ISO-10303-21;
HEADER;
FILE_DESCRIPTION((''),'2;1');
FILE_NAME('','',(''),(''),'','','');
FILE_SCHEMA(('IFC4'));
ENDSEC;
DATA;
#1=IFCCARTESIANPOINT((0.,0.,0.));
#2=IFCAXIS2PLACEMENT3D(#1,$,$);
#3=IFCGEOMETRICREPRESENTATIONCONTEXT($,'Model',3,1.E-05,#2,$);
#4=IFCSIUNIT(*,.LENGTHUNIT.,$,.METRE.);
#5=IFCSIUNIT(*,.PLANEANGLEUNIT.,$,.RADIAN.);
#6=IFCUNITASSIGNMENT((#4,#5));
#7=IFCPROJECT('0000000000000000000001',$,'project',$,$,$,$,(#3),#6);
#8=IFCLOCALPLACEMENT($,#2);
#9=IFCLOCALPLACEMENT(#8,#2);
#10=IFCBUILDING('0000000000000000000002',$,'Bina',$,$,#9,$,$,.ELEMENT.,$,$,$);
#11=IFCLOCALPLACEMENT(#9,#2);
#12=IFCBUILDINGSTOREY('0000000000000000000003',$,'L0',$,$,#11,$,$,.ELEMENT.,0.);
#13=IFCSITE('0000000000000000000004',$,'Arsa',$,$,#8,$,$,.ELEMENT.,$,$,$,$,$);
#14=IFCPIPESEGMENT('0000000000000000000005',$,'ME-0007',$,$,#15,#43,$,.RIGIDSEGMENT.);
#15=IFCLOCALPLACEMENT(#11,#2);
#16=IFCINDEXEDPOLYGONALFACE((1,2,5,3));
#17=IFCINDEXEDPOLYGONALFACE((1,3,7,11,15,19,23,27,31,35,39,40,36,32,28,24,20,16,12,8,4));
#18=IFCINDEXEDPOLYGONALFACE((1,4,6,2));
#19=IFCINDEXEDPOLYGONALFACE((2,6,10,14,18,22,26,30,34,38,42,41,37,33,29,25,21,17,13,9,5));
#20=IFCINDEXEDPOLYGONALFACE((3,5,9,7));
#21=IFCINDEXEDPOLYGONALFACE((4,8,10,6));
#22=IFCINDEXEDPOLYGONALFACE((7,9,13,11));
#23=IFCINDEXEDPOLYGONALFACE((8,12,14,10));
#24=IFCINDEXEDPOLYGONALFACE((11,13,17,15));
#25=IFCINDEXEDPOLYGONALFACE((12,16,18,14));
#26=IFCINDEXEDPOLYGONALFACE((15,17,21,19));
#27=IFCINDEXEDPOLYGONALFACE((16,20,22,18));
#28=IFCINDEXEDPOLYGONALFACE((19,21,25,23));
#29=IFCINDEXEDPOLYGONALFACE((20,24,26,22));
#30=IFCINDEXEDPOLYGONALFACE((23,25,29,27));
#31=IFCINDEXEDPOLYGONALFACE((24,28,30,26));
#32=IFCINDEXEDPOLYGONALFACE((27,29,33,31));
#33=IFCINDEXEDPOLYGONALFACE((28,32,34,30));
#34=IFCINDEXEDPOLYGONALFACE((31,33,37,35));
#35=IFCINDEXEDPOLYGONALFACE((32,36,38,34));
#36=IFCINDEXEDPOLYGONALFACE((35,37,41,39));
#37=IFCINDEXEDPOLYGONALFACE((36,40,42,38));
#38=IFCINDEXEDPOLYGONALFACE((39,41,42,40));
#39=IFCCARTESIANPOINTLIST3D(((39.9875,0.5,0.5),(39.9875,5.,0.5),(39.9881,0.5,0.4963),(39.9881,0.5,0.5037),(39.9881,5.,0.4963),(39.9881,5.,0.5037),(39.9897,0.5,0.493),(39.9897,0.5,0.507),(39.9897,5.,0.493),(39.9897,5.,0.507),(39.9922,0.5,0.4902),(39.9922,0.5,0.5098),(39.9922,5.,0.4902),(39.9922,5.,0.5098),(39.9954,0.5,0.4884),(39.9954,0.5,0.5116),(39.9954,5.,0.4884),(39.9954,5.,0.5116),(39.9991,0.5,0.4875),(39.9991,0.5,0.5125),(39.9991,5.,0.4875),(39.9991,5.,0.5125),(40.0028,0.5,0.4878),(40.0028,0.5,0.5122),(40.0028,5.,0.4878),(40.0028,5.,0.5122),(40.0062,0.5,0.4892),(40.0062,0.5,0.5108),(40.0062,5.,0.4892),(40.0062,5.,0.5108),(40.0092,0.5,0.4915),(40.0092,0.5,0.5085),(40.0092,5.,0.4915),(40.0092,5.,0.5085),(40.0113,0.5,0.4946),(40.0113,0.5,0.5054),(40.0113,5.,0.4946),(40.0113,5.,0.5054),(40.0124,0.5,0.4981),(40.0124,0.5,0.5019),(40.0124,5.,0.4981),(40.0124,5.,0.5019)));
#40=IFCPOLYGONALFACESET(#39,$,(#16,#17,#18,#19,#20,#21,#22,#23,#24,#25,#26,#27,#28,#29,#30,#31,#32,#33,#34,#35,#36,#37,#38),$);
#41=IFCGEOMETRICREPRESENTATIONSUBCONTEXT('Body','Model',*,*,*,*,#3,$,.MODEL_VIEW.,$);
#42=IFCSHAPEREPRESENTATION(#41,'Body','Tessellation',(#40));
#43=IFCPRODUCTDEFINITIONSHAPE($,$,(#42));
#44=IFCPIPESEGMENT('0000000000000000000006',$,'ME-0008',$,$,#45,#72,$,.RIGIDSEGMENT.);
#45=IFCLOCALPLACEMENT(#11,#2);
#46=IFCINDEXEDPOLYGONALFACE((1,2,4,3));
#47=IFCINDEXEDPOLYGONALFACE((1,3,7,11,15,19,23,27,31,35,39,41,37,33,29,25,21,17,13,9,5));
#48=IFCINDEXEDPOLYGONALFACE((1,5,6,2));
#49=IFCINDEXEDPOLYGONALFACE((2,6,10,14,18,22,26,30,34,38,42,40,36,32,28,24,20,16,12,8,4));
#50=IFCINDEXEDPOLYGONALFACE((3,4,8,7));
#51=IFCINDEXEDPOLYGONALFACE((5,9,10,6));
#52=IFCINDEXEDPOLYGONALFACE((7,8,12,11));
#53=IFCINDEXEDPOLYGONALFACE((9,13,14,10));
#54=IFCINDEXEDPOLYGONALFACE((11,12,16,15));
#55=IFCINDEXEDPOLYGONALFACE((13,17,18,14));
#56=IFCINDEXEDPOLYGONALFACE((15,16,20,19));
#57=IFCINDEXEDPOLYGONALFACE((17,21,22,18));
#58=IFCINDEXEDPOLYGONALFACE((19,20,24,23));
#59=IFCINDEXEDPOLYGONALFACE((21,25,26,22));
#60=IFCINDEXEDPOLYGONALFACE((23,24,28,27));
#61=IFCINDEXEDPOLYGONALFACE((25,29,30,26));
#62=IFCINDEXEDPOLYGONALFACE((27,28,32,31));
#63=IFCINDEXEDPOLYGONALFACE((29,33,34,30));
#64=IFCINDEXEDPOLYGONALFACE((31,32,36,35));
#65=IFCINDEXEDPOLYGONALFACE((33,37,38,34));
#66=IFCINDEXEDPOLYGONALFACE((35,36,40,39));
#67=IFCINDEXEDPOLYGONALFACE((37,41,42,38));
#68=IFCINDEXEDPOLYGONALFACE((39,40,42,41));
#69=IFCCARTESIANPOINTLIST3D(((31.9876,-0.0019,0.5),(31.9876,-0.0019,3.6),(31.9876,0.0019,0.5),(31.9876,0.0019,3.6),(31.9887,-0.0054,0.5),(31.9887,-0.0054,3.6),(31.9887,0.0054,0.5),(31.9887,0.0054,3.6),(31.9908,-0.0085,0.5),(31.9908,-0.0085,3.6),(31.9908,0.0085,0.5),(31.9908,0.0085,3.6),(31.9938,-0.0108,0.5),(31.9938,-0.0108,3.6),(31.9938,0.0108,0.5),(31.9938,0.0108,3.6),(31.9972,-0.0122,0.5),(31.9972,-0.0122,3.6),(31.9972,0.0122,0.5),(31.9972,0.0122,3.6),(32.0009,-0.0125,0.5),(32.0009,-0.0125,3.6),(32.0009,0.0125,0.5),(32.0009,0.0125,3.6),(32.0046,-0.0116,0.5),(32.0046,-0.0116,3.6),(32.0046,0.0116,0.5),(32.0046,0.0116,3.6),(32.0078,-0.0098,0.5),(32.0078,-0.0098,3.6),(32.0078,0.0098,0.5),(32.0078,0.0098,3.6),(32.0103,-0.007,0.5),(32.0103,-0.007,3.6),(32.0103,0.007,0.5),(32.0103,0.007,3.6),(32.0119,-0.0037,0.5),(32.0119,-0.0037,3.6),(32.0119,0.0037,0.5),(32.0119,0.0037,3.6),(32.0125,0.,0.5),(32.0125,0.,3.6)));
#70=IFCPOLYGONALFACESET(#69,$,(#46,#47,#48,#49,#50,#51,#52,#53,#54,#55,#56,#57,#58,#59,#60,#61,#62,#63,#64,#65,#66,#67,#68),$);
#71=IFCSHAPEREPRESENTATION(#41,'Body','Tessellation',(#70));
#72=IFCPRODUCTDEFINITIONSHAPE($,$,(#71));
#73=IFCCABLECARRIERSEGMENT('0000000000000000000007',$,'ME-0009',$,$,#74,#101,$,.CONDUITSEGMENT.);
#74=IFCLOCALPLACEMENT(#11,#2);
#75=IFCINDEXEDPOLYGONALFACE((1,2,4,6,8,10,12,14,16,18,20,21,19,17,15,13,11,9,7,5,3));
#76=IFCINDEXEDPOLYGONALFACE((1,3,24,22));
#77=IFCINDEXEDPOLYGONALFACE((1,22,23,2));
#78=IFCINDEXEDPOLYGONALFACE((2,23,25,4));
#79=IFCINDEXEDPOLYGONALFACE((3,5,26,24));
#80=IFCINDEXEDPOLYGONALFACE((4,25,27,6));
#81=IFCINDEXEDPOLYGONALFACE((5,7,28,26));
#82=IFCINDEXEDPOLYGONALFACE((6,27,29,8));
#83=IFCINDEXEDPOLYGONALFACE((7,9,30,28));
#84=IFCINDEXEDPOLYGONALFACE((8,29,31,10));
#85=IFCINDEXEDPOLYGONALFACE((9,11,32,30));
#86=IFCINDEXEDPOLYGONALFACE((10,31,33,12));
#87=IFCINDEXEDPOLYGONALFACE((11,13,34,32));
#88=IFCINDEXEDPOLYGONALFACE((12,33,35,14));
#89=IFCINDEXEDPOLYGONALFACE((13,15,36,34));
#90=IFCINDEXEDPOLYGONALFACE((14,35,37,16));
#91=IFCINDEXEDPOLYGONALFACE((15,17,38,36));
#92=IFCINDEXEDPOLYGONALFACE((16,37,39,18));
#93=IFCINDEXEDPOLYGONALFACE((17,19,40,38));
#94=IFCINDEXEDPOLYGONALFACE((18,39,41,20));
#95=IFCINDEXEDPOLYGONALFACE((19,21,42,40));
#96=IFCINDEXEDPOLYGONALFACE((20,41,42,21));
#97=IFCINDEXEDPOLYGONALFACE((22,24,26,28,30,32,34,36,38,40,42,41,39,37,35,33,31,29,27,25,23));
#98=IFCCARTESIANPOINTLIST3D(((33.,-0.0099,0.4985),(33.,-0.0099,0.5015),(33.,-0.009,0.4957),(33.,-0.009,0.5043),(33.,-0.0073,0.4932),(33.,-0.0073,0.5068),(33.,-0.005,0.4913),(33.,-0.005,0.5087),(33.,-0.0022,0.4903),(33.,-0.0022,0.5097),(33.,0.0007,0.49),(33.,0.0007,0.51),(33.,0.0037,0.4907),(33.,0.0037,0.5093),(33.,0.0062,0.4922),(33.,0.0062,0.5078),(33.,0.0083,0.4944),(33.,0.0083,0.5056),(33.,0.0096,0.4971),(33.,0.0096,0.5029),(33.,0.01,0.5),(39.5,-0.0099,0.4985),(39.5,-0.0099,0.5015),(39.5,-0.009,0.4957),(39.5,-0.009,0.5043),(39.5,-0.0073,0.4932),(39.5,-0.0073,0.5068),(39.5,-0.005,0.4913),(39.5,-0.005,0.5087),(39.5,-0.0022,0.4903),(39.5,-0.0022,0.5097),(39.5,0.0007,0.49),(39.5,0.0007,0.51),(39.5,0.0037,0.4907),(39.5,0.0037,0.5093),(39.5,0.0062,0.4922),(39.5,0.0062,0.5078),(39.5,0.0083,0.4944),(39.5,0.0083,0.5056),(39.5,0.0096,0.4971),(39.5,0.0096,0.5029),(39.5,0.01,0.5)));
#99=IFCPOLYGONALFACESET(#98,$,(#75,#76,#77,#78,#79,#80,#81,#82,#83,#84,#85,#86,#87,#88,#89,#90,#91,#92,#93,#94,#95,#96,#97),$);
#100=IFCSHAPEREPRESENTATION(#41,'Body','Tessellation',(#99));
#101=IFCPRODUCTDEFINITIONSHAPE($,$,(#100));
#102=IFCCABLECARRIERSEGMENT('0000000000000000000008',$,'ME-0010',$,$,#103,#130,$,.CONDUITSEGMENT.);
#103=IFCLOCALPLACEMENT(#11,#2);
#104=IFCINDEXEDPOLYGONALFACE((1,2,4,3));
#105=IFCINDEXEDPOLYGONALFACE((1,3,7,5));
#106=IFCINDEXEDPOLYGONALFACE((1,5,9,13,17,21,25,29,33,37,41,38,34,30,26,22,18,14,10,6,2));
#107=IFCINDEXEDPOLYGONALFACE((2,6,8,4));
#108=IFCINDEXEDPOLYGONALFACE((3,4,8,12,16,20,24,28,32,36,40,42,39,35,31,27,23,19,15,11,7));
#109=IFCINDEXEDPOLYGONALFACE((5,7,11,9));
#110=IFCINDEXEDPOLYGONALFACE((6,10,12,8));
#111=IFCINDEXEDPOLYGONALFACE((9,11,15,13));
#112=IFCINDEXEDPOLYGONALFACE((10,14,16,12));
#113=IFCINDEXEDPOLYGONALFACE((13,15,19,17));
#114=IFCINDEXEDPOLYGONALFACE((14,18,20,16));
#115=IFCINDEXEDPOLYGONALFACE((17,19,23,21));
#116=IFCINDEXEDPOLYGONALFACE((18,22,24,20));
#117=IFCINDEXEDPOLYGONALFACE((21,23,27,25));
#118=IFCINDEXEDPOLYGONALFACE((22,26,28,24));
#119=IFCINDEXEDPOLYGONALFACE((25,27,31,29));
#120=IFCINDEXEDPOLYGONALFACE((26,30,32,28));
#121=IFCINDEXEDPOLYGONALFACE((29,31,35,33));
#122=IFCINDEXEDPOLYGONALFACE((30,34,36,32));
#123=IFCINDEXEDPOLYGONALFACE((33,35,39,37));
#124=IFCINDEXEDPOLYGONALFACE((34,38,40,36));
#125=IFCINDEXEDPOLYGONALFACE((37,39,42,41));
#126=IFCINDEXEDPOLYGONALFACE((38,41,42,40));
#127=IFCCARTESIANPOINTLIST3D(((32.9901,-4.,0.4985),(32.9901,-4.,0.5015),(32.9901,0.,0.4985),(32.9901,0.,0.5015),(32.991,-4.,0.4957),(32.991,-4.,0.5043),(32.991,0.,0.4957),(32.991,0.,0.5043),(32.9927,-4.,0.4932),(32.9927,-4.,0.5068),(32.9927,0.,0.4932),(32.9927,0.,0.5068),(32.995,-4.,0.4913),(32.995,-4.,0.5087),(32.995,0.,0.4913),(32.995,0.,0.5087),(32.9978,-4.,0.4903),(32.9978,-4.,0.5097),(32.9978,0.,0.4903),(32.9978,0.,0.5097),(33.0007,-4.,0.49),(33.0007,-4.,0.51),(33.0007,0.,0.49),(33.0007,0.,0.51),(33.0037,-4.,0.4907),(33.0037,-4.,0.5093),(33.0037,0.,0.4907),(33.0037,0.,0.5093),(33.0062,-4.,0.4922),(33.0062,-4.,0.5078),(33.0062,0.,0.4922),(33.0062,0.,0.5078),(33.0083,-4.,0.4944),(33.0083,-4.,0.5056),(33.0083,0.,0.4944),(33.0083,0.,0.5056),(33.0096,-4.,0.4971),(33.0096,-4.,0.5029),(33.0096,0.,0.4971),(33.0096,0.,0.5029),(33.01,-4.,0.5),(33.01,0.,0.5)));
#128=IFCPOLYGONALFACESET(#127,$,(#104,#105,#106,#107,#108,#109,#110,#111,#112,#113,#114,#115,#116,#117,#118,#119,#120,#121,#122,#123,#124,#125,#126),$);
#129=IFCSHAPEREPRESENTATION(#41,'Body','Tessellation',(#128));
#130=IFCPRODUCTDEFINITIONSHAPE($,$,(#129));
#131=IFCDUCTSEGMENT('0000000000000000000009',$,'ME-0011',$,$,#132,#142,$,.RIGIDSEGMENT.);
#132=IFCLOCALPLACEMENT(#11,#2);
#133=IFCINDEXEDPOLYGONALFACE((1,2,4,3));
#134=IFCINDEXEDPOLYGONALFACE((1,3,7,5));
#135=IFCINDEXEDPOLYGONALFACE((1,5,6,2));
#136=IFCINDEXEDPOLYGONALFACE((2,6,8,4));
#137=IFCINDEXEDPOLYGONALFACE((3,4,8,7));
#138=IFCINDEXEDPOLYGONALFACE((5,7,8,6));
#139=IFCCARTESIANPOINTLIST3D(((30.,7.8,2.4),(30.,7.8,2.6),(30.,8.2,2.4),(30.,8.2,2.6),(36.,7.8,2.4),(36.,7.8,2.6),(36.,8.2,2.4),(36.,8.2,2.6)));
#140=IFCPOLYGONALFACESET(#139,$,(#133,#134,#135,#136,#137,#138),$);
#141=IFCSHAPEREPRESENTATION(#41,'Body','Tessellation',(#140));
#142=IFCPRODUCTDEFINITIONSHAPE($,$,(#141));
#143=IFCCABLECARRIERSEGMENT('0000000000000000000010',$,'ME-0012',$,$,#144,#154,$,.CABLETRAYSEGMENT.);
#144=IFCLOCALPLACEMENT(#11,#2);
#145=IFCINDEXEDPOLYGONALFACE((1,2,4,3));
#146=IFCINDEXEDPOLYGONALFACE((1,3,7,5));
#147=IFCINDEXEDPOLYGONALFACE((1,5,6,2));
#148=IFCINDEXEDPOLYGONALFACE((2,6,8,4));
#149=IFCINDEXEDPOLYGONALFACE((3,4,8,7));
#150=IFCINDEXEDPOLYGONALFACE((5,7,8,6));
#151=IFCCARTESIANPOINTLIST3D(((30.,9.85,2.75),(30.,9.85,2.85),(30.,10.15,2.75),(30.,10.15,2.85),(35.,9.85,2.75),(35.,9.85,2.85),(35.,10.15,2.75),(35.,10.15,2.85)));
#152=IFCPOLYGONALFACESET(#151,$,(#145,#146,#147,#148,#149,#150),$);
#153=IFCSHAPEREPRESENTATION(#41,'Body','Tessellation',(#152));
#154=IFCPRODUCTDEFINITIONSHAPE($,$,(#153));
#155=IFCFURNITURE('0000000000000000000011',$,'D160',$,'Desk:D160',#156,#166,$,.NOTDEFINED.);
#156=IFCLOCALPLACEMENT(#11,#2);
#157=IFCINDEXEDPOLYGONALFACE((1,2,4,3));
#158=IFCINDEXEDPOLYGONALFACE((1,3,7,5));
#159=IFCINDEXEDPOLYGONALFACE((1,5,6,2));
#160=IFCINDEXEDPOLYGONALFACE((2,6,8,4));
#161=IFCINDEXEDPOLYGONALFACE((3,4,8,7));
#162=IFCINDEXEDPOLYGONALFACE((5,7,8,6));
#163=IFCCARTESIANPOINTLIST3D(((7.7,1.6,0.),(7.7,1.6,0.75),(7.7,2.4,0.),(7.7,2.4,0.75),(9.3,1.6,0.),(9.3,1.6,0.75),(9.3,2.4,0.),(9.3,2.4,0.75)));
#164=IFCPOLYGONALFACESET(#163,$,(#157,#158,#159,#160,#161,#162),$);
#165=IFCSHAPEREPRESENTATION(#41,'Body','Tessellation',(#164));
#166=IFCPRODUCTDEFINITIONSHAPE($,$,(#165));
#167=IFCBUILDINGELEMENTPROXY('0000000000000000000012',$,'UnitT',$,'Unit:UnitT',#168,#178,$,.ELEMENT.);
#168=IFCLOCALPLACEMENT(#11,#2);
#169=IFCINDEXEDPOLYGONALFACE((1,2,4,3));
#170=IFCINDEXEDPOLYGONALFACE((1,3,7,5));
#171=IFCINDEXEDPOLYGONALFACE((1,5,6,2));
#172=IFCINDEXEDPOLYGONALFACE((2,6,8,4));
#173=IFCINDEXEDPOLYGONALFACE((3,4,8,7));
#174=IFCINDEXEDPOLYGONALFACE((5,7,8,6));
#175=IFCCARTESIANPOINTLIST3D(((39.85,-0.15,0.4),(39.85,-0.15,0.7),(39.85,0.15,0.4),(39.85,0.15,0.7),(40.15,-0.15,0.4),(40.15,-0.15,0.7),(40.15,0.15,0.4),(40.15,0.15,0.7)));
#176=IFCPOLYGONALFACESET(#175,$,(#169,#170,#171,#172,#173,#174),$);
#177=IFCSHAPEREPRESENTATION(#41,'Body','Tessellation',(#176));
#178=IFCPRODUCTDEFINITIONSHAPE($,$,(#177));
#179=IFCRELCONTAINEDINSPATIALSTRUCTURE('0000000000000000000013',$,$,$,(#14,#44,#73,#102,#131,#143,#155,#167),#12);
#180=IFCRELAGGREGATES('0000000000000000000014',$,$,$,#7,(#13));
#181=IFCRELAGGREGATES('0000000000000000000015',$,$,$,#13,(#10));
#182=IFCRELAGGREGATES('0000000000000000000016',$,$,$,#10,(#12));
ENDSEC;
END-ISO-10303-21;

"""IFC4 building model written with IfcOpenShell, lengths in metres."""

from ifc_helpers import new_model, si_unit, frame, origin, origin_2d, place, context, subcontext, project, spatial, rectangle, circle, extrude, element, save


model = new_model("IFC4")

# Units and contexts
model_context = context("Model", 3, precision=1e-05, world=origin())
body_context = subcontext(model_context, "Body", "Model", "MODEL_VIEW")
ifc_project = project(units=[si_unit("LENGTHUNIT", "METRE"), si_unit("PLANEANGLEUNIT", "RADIAN")], contexts=[model_context])

# Site, building, storey
site_placement = place(None, origin())
site = spatial("IfcSite", under=ifc_project, at=site_placement, Name="Arsa", CompositionType="ELEMENT")
building_placement = place(site_placement, origin())
building = spatial("IfcBuilding", under=site, at=building_placement, Name="Bina", CompositionType="ELEMENT")
storey_placement = place(building_placement, origin())
storey = spatial("IfcBuildingStorey", under=building, at=storey_placement, Name="L0", CompositionType="ELEMENT", Elevation=0.0)

# Pipe segments
pipe_segment_1_placement = place(storey_placement, origin())
element("IfcPipeSegment", 1, at=pipe_segment_1_placement, inside=storey, Name="ME-0007", PredefinedType="RIGIDSEGMENT", context=body_context, shape_type="SweptSolid", body=[
    extrude(circle(Radius=0.0125, at=origin_2d()), frame((40.0, 0.5, 0.5), z_axis=(0.0, 1.0, 0.0), x_axis=(-1.0, 0.0, 0.0)), (0.0, 0.0, 1.0), 4.5),
])
pipe_segment_2_placement = place(storey_placement, origin())
element("IfcPipeSegment", 2, at=pipe_segment_2_placement, inside=storey, Name="ME-0008", PredefinedType="RIGIDSEGMENT", context=body_context, shape_type="SweptSolid", body=[
    extrude(circle(Radius=0.0125, at=origin_2d()), frame((32.0, 0.0, 0.5), z_axis=(0.0, 0.0, 1.0), x_axis=(1.0, 0.0, 0.0)), (0.0, 0.0, 1.0), 3.1),
])

# Cable carrier segments
cable_carrier_segment_1_placement = place(storey_placement, origin())
element("IfcCableCarrierSegment", 3, at=cable_carrier_segment_1_placement, inside=storey, Name="ME-0009", PredefinedType="CONDUITSEGMENT", context=body_context, shape_type="SweptSolid", body=[
    extrude(circle(Radius=0.01, at=origin_2d()), frame((33.0, 0.0, 0.5), z_axis=(1.0, 0.0, 0.0), x_axis=(0.0, 1.0, 0.0)), (0.0, 0.0, 1.0), 6.5),
])
cable_carrier_segment_2_placement = place(storey_placement, origin())
element("IfcCableCarrierSegment", 4, at=cable_carrier_segment_2_placement, inside=storey, Name="ME-0010", PredefinedType="CONDUITSEGMENT", context=body_context, shape_type="SweptSolid", body=[
    extrude(circle(Radius=0.01, at=origin_2d()), frame((33.0, 0.0, 0.5), z_axis=(0.0, -1.0, 0.0), x_axis=(1.0, 0.0, 0.0)), (0.0, 0.0, 1.0), 4.0),
])

# Duct segment
duct_segment_placement = place(storey_placement, origin())
element("IfcDuctSegment", 5, at=duct_segment_placement, inside=storey, Name="ME-0011", PredefinedType="RIGIDSEGMENT", context=body_context, shape_type="SweptSolid", body=[
    extrude(rectangle(XDim=0.4, YDim=0.2, at=origin_2d()), frame((30.0, 8.0, 2.5), z_axis=(1.0, 0.0, 0.0), x_axis=(0.0, 1.0, 0.0)), (0.0, 0.0, 1.0), 6.0),
])

# Cable carrier segment
cable_carrier_segment_3_placement = place(storey_placement, origin())
element("IfcCableCarrierSegment", 6, at=cable_carrier_segment_3_placement, inside=storey, Name="ME-0012", PredefinedType="CABLETRAYSEGMENT", context=body_context, shape_type="SweptSolid", body=[
    extrude(rectangle(XDim=0.3, YDim=0.1, at=origin_2d()), frame((30.0, 10.0, 2.8), z_axis=(1.0, 0.0, 0.0), x_axis=(0.0, 1.0, 0.0)), (0.0, 0.0, 1.0), 5.0),
])

# Furniture
furniture_placement = place(storey_placement, frame((8.5, 2.0, 0.0), z_axis=(0.0, 0.0, 1.0), x_axis=(1.0, 0.0, 0.0)))
element("IfcFurniture", 7, at=furniture_placement, inside=storey, Name="D160", ObjectType="Desk:D160", PredefinedType="NOTDEFINED", context=body_context, shape_type="SweptSolid", body=[
    extrude(rectangle(XDim=1.6, YDim=0.8, at=origin_2d()), origin(), (0.0, 0.0, 1.0), 0.75),
])

# Building element proxy
proxy_placement = place(storey_placement, frame((40.0, 0.0, 0.4), z_axis=(0.0, 0.0, 1.0), x_axis=(1.0, 0.0, 0.0)))
element("IfcBuildingElementProxy", 8, at=proxy_placement, inside=storey, Name="UnitT", ObjectType="Unit:UnitT", PredefinedType="ELEMENT", context=body_context, shape_type="SweptSolid", body=[
    extrude(rectangle(XDim=0.3, YDim=0.3, at=origin_2d()), origin(), (0.0, 0.0, 1.0), 0.3),
])

save(model, "model.ifc")
